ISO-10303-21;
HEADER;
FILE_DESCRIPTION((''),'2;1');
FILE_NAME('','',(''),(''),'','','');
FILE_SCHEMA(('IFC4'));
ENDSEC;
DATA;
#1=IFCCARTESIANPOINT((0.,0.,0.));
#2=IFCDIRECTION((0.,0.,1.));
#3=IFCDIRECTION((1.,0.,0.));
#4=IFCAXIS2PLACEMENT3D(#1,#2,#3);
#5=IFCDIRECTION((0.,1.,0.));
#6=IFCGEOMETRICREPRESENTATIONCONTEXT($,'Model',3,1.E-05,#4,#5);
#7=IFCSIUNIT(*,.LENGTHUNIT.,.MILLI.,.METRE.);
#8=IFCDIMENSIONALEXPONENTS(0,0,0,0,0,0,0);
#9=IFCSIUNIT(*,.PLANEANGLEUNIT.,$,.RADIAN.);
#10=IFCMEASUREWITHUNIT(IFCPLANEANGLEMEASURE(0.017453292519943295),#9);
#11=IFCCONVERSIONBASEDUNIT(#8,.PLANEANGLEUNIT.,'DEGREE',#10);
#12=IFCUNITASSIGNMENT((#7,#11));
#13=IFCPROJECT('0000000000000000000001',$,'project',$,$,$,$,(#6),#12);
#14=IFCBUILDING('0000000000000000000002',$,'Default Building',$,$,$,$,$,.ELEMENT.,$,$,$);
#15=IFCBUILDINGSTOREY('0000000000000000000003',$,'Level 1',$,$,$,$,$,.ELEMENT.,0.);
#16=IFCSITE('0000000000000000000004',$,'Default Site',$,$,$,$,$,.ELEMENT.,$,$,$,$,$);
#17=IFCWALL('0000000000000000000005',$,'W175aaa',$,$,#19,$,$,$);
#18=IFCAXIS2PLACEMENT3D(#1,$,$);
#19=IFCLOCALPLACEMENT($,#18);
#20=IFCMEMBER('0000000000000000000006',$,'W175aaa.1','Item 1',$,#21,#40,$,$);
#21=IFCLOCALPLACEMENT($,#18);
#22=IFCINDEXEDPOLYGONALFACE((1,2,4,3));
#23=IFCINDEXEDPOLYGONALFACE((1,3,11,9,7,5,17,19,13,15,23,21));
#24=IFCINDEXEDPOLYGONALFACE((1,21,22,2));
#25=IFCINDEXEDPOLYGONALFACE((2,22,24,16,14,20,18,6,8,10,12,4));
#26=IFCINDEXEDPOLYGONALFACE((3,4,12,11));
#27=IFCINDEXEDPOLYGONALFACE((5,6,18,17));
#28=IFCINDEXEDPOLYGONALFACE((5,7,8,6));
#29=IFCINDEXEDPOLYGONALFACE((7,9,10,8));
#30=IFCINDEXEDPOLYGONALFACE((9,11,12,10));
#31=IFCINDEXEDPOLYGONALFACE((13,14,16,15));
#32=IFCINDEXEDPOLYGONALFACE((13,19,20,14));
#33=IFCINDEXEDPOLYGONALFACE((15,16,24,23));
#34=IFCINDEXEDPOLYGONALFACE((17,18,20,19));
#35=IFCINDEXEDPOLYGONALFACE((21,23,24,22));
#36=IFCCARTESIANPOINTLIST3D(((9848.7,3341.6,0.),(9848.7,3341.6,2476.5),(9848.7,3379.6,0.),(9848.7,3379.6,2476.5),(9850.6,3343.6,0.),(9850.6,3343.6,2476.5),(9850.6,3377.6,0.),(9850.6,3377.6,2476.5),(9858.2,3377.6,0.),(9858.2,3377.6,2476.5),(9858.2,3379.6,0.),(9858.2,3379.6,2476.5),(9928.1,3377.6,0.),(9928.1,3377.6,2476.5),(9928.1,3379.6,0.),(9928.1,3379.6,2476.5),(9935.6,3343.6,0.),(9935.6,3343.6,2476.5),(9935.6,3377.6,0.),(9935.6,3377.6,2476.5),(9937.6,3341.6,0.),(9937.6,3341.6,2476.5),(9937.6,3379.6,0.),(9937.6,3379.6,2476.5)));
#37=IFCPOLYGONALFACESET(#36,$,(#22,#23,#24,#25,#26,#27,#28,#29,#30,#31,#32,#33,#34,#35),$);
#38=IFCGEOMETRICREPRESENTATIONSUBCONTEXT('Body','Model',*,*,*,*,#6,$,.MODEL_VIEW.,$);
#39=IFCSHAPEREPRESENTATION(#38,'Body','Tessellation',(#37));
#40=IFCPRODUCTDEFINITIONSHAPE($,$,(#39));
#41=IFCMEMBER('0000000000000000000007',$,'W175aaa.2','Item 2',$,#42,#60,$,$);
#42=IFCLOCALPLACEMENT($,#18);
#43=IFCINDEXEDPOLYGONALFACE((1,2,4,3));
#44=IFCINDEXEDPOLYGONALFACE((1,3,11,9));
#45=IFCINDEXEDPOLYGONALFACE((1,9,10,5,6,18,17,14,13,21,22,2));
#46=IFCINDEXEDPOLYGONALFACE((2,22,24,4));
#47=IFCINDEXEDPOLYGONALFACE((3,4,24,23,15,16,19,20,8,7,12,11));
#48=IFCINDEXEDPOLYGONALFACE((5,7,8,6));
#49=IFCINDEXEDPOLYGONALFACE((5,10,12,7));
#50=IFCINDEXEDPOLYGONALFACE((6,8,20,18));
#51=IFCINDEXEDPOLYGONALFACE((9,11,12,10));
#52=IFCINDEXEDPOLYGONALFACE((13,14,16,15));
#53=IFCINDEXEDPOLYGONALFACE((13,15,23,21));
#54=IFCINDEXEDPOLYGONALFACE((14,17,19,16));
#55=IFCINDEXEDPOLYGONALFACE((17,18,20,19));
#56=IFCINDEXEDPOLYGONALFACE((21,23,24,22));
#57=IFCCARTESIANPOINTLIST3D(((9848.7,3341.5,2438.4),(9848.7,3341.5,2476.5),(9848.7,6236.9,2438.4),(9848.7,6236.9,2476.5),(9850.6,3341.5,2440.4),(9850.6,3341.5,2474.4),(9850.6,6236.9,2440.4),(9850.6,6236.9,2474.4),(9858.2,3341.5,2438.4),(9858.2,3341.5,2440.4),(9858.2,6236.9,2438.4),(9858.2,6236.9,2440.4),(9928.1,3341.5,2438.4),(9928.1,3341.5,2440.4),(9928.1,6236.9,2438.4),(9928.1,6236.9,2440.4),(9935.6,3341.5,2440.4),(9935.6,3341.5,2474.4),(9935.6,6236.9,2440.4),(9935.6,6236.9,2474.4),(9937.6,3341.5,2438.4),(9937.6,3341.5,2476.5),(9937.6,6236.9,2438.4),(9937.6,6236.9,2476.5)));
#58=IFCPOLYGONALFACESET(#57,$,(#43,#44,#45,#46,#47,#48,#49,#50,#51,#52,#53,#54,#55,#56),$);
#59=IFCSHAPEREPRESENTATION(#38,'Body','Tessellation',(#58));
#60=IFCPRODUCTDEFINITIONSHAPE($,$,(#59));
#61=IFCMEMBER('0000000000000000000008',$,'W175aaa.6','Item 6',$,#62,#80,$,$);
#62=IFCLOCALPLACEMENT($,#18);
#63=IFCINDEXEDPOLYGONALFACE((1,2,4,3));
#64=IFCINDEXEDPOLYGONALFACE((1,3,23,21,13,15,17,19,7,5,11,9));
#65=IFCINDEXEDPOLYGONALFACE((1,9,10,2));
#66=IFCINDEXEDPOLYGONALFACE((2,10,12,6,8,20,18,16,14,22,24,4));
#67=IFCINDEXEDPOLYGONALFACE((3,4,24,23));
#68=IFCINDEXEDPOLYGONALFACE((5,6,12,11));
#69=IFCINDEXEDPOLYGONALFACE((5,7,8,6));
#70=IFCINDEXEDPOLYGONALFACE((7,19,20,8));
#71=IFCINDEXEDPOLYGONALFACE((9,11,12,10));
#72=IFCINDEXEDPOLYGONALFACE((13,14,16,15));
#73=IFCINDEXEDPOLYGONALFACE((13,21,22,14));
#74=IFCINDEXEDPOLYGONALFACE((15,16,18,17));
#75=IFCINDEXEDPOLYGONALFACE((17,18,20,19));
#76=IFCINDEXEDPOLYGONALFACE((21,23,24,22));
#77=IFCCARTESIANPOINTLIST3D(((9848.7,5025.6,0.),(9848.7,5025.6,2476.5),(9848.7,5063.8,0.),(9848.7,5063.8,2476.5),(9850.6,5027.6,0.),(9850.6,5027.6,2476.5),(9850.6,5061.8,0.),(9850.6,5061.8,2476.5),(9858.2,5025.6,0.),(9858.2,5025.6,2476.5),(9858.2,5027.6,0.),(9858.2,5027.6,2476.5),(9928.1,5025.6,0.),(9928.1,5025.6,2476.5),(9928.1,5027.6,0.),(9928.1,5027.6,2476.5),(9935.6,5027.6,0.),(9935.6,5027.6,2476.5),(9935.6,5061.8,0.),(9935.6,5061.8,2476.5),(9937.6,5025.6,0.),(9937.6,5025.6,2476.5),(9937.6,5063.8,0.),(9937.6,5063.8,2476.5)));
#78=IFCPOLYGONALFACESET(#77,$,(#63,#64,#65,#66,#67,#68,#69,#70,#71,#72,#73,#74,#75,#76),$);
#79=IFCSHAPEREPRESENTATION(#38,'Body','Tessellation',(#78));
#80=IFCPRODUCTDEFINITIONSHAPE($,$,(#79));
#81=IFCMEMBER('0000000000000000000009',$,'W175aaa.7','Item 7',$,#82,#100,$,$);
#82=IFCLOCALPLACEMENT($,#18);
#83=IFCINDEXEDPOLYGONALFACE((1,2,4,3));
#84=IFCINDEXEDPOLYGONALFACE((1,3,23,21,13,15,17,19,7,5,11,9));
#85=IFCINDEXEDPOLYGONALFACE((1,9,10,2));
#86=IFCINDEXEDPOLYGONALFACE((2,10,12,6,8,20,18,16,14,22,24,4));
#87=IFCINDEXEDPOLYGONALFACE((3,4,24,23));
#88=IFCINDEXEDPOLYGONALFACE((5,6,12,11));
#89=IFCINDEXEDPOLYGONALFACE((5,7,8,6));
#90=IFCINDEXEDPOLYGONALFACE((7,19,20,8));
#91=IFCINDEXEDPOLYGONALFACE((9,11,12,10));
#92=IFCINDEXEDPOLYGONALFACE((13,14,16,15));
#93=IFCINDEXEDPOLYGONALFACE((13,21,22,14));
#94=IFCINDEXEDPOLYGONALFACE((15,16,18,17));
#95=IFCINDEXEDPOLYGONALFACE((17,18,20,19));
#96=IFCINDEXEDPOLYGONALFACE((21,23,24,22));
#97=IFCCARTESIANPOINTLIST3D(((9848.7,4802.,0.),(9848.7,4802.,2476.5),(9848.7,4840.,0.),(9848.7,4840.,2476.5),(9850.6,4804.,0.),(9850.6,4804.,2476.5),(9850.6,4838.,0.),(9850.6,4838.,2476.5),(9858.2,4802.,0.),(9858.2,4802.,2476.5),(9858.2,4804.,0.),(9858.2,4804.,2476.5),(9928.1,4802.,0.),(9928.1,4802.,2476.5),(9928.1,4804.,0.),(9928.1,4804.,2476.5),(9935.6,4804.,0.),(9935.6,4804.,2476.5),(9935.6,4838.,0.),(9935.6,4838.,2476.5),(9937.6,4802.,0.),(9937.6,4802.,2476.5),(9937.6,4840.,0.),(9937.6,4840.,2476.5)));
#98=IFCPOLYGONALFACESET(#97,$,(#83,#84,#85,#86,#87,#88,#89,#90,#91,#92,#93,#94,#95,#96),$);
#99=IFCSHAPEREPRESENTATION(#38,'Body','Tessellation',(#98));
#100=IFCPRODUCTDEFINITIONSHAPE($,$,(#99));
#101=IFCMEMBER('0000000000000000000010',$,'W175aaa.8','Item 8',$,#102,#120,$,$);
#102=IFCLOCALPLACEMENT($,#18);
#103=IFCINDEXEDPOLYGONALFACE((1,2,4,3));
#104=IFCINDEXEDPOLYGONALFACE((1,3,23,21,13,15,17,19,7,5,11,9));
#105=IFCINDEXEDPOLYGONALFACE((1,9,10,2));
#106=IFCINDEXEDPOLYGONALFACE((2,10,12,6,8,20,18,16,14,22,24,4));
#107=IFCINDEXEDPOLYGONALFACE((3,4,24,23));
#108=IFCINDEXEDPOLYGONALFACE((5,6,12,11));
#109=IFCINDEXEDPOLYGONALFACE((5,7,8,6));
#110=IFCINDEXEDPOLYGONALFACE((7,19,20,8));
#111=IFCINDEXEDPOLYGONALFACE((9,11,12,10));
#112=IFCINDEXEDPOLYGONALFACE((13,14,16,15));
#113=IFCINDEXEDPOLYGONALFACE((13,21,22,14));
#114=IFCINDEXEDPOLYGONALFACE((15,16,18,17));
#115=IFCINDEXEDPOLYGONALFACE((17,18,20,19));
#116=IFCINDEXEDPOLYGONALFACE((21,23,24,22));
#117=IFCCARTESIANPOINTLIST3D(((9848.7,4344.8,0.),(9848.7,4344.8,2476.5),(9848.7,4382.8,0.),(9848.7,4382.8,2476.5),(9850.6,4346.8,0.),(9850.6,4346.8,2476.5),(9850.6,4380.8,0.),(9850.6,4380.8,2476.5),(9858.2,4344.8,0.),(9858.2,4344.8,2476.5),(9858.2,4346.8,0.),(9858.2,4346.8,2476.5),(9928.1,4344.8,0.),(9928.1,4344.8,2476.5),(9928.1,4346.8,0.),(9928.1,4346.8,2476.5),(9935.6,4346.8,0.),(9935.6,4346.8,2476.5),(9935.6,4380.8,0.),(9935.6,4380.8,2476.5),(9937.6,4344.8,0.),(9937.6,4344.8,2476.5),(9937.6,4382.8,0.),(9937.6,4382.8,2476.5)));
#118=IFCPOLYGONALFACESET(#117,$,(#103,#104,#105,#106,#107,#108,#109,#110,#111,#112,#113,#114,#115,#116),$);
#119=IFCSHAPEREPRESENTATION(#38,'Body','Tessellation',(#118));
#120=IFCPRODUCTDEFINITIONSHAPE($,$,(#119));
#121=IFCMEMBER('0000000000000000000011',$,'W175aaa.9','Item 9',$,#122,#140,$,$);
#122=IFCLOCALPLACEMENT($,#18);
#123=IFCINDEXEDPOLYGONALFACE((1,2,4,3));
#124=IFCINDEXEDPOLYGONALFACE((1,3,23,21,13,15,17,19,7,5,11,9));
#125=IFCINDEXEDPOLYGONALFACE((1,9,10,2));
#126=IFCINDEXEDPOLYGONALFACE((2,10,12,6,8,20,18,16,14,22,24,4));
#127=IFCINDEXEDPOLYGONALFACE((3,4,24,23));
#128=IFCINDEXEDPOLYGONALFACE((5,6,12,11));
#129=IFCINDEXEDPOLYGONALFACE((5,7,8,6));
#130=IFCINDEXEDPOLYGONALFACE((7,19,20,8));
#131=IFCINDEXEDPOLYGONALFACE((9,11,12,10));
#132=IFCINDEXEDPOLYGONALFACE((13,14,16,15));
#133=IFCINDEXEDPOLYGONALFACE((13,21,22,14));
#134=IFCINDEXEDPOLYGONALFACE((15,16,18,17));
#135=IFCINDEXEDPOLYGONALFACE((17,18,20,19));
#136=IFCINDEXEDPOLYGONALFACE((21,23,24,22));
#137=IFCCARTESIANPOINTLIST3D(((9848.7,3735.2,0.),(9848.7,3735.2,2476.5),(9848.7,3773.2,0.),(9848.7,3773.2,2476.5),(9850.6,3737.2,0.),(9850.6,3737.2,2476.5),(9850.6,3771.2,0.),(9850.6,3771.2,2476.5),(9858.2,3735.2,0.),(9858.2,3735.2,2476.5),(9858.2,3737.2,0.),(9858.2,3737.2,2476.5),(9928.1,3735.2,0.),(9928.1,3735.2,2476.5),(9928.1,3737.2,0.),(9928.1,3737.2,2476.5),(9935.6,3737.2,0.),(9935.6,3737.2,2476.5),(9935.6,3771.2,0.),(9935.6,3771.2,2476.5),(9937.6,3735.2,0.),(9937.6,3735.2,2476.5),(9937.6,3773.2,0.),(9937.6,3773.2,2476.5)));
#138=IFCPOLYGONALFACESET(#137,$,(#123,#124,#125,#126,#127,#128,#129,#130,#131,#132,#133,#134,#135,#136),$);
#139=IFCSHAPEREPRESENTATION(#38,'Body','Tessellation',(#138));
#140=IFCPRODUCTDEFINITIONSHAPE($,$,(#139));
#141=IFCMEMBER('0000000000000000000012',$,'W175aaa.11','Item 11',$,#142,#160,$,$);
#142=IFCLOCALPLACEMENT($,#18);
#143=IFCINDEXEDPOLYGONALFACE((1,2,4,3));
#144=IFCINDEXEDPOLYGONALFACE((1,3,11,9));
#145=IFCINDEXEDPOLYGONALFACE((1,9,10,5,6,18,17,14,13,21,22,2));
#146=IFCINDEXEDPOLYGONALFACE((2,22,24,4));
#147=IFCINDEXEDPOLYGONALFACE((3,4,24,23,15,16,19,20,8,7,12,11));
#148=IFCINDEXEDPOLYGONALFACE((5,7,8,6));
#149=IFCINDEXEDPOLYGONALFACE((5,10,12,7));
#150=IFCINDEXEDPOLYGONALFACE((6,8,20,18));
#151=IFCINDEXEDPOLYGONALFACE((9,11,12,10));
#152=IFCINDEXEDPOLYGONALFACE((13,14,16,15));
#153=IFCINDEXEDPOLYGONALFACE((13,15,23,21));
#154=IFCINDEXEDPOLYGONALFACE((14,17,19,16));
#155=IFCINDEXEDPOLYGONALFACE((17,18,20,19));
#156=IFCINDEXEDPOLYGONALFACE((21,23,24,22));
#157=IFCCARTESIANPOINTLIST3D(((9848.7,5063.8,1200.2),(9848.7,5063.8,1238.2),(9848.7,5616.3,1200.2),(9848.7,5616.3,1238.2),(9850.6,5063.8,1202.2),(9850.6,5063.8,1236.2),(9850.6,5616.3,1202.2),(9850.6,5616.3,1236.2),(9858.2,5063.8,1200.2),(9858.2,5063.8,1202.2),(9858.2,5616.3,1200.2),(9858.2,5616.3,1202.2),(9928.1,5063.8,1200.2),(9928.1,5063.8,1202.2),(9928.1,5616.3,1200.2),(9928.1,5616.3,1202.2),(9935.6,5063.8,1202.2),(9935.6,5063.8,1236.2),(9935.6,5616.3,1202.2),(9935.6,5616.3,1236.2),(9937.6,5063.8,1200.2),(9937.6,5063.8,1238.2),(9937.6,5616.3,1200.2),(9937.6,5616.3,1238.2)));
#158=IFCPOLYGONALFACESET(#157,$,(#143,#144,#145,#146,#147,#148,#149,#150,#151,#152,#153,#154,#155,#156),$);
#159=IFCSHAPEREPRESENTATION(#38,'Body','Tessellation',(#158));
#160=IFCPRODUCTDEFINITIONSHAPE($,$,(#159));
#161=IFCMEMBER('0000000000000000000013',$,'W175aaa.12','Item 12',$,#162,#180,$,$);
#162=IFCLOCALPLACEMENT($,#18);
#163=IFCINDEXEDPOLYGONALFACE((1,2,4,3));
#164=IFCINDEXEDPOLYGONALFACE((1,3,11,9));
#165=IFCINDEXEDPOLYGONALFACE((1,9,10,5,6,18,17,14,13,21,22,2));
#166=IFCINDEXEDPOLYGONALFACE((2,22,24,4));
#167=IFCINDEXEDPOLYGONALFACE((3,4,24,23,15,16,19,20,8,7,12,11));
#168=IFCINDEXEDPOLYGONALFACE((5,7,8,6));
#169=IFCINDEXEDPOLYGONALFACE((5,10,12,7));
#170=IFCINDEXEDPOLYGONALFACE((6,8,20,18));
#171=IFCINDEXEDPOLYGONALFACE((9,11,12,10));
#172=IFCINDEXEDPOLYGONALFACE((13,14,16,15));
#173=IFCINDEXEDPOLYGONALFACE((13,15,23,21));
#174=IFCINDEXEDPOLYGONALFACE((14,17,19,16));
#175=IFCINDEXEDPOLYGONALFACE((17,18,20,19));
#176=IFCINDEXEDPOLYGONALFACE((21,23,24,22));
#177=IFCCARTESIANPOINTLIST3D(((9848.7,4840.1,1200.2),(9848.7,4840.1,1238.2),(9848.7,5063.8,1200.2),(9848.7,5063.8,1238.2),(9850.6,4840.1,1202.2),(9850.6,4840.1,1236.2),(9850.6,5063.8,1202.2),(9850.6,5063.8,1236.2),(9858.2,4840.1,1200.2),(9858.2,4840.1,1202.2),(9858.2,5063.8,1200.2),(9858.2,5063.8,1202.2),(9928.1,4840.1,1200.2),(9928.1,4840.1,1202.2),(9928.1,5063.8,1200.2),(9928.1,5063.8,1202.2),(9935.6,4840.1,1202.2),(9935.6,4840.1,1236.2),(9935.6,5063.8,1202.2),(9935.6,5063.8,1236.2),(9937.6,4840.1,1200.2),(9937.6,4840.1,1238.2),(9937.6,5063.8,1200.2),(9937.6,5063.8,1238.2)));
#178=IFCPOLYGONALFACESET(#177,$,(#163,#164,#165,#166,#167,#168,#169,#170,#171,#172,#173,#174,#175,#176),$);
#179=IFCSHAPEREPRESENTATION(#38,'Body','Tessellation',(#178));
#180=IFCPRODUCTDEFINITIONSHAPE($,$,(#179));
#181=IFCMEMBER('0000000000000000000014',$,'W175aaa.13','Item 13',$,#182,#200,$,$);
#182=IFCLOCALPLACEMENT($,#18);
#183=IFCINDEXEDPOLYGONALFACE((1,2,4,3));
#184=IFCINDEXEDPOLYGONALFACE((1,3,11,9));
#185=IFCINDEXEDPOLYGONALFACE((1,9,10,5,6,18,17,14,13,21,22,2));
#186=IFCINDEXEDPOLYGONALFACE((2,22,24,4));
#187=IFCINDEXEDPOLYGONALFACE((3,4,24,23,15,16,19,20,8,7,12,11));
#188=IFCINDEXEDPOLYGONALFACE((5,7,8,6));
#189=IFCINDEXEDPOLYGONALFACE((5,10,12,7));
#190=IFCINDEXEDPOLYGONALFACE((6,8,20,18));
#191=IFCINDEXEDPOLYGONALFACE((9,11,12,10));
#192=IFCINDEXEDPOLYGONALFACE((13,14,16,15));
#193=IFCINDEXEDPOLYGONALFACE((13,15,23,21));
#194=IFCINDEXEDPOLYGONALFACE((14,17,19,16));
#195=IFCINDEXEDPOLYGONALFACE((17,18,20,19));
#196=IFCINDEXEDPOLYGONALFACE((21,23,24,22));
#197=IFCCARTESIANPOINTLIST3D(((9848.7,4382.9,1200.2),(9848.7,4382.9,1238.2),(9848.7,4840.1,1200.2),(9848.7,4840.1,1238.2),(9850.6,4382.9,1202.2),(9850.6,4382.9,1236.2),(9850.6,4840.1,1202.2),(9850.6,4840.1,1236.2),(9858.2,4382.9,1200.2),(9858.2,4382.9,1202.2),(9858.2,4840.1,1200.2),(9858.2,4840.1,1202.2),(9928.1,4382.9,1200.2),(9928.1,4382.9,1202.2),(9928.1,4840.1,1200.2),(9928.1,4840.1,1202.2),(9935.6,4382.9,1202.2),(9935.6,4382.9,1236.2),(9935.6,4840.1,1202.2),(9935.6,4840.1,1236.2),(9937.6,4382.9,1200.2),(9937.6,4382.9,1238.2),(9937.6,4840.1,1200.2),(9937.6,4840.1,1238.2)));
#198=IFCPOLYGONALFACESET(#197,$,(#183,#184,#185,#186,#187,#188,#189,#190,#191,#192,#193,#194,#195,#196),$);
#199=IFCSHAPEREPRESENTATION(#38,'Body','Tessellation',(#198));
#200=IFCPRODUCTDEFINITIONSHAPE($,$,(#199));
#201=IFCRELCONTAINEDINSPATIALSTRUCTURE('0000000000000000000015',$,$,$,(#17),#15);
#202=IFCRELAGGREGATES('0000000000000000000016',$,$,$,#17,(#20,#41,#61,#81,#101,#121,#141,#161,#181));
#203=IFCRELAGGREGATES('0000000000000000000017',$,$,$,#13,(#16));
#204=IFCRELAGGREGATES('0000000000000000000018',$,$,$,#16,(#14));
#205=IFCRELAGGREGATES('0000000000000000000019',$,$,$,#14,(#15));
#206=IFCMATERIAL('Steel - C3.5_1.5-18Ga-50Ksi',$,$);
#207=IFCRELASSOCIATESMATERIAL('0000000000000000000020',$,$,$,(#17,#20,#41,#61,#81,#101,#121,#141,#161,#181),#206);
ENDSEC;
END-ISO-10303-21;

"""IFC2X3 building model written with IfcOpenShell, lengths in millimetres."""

from ifc_helpers import new_model, entity, si_unit, converted_unit, direction, frame, origin, origin_with_axes, origin_2d_with_axis, place, context, subcontext, project, spatial, c_section, extrude, material, element, aggregate, save


model = new_model("IFC2X3")

# Units and contexts
model_context = context("Model", 3, precision=1e-05, world=origin_with_axes(), true_north=direction((0.0, 1.0, 0.0)))
body_context = subcontext(model_context, "Body", "Model", "MODEL_VIEW")
ifc_project = project(units=[si_unit("LENGTHUNIT", "METRE", prefix="MILLI"), converted_unit("PLANEANGLEUNIT", "DEGREE", entity("IfcPlaneAngleMeasure", 0.017453292519943295), si_unit("PLANEANGLEUNIT", "RADIAN"), dimensions=[0, 0, 0, 0, 0, 0, 0])], contexts=[model_context])

# Site, building, storey
site = spatial("IfcSite", under=ifc_project, Name="Default Site", CompositionType="ELEMENT")
building = spatial("IfcBuilding", under=site, Name="Default Building", CompositionType="ELEMENT")
storey = spatial("IfcBuildingStorey", under=building, Name="Level 1", CompositionType="ELEMENT", Elevation=0.0)

# Wall, members
ifc_material_1 = material(Name="Steel - C3.5_1.5-18Ga-50Ksi")
wall = element("IfcWall", 1, inside=storey, material=ifc_material_1, Name="W175aaa")
member_1_placement = place(None, frame((9893.1, 3360.6, 0.0), z_axis=(0.0, 0.0, 1.0), x_axis=(0.0, 1.0, 0.0)))
member_1 = element("IfcMember", 2, at=member_1_placement, material=ifc_material_1, Name="W175aaa.1", Description="Item 1", context=body_context, shape_type="SweptSolid", body=[
    extrude(c_section(Depth=88.9, Width=38.1, WallThickness=2.0, Girth=9.5, at=origin_2d_with_axis()), origin(), (0.0, 0.0, 1.0), 2476.5),
])
member_2_placement = place(None, frame((9893.1, 3341.5, 2457.4), z_axis=(0.0, 1.0, 0.0), x_axis=(0.0, 0.0, -1.0)))
member_2 = element("IfcMember", 3, at=member_2_placement, material=ifc_material_1, Name="W175aaa.2", Description="Item 2", context=body_context, shape_type="SweptSolid", body=[
    extrude(c_section(Depth=88.9, Width=38.1, WallThickness=2.0, Girth=9.5, at=origin_2d_with_axis()), origin(), (0.0, 0.0, 1.0), 2895.4),
])
member_3_placement = place(None, frame((9893.1, 5044.7, 2476.5), z_axis=(0.0, 0.0, -1.0), x_axis=(0.0, -1.0, 0.0)))
member_3 = element("IfcMember", 4, at=member_3_placement, material=ifc_material_1, Name="W175aaa.6", Description="Item 6", context=body_context, shape_type="SweptSolid", body=[
    extrude(c_section(Depth=88.9, Width=38.1, WallThickness=2.0, Girth=9.5, at=origin_2d_with_axis()), origin(), (0.0, 0.0, 1.0), 2476.5),
])
member_4_placement = place(None, frame((9893.1, 4821.0, 2476.5), z_axis=(0.0, 0.0, -1.0), x_axis=(0.0, -1.0, 0.0)))
member_4 = element("IfcMember", 5, at=member_4_placement, material=ifc_material_1, Name="W175aaa.7", Description="Item 7", context=body_context, shape_type="SweptSolid", body=[
    extrude(c_section(Depth=88.9, Width=38.1, WallThickness=2.0, Girth=9.5, at=origin_2d_with_axis()), origin(), (0.0, 0.0, 1.0), 2476.5),
])
member_5_placement = place(None, frame((9893.1, 4363.8, 2476.5), z_axis=(0.0, 0.0, -1.0), x_axis=(0.0, -1.0, 0.0)))
member_5 = element("IfcMember", 6, at=member_5_placement, material=ifc_material_1, Name="W175aaa.8", Description="Item 8", context=body_context, shape_type="SweptSolid", body=[
    extrude(c_section(Depth=88.9, Width=38.1, WallThickness=2.0, Girth=9.5, at=origin_2d_with_axis()), origin(), (0.0, 0.0, 1.0), 2476.5),
])
member_6_placement = place(None, frame((9893.1, 3754.2, 2476.5), z_axis=(0.0, 0.0, -1.0), x_axis=(0.0, -1.0, 0.0)))
member_6 = element("IfcMember", 7, at=member_6_placement, material=ifc_material_1, Name="W175aaa.9", Description="Item 9", context=body_context, shape_type="SweptSolid", body=[
    extrude(c_section(Depth=88.9, Width=38.1, WallThickness=2.0, Girth=9.5, at=origin_2d_with_axis()), origin(), (0.0, 0.0, 1.0), 2476.5),
])
member_7_placement = place(None, frame((9893.1, 5063.8, 1219.2), z_axis=(0.0, 1.0, 0.0), x_axis=(0.0, 0.0, -1.0)))
member_7 = element("IfcMember", 8, at=member_7_placement, material=ifc_material_1, Name="W175aaa.11", Description="Item 11", context=body_context, shape_type="SweptSolid", body=[
    extrude(c_section(Depth=88.9, Width=38.1, WallThickness=2.0, Girth=9.5, at=origin_2d_with_axis()), origin(), (0.0, 0.0, 1.0), 552.5),
])
member_8_placement = place(None, frame((9893.1, 4840.1, 1219.2), z_axis=(0.0, 1.0, 0.0), x_axis=(0.0, 0.0, -1.0)))
member_8 = element("IfcMember", 9, at=member_8_placement, material=ifc_material_1, Name="W175aaa.12", Description="Item 12", context=body_context, shape_type="SweptSolid", body=[
    extrude(c_section(Depth=88.9, Width=38.1, WallThickness=2.0, Girth=9.5, at=origin_2d_with_axis()), origin(), (0.0, 0.0, 1.0), 223.7),
])
member_9_placement = place(None, frame((9893.1, 4382.9, 1219.2), z_axis=(0.0, 1.0, 0.0), x_axis=(0.0, 0.0, -1.0)))
member_9 = element("IfcMember", 10, at=member_9_placement, material=ifc_material_1, Name="W175aaa.13", Description="Item 13", context=body_context, shape_type="SweptSolid", body=[
    extrude(c_section(Depth=88.9, Width=38.1, WallThickness=2.0, Girth=9.5, at=origin_2d_with_axis()), origin(), (0.0, 0.0, 1.0), 457.2),
])
aggregate(wall, [member_1, member_2, member_3, member_4, member_5, member_6, member_7, member_8, member_9])

save(model, "model.ifc")
